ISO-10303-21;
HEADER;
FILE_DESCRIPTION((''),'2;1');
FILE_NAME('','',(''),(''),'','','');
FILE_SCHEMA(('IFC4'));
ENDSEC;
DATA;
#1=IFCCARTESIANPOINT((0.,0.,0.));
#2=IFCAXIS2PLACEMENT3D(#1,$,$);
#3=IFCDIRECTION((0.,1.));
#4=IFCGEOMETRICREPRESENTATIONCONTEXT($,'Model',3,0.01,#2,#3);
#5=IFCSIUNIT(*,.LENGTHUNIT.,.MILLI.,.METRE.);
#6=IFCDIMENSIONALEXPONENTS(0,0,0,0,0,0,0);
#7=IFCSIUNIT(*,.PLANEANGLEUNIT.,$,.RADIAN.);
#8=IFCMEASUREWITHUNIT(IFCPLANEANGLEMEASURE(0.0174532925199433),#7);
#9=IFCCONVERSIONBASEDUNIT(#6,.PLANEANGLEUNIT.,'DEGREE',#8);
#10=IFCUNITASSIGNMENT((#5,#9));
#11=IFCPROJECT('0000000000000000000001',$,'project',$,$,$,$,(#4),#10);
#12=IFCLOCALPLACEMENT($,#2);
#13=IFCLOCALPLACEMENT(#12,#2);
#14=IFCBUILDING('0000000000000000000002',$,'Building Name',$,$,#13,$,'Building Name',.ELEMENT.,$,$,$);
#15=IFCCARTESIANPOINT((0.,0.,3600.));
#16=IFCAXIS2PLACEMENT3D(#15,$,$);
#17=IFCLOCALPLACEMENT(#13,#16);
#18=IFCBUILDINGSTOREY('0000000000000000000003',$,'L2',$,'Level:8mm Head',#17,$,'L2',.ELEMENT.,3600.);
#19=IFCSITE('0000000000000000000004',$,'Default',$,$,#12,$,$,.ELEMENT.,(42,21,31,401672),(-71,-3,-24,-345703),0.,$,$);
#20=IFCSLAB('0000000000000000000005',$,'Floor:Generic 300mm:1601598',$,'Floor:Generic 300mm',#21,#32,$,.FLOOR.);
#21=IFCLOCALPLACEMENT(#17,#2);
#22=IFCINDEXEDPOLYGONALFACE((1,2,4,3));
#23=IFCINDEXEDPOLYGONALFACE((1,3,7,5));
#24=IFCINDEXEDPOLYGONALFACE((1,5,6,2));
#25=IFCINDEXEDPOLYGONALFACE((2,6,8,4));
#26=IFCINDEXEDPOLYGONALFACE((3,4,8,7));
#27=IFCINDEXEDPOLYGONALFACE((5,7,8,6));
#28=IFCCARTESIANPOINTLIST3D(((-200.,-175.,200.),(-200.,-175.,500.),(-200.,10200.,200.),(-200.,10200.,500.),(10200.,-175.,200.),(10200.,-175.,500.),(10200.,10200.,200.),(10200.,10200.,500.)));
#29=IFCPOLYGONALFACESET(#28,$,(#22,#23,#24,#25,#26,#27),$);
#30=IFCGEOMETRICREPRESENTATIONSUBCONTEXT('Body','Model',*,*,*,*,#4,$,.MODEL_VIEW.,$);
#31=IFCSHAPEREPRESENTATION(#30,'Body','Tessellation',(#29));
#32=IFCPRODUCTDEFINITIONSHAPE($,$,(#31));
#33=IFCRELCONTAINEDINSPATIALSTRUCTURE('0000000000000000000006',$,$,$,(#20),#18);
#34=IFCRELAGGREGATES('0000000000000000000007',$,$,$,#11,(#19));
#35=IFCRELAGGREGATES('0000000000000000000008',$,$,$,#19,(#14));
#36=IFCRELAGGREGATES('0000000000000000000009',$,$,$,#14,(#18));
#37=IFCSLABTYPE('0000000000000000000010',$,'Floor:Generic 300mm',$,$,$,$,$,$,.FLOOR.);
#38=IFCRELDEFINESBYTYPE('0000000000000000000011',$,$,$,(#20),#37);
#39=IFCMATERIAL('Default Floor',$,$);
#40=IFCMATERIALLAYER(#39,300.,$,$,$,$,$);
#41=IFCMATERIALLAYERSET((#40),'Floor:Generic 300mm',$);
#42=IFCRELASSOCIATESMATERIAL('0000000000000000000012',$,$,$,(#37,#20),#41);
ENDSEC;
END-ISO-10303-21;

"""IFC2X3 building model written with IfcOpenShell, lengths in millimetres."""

from ifc_helpers import new_model, entity, si_unit, converted_unit, direction, frame, frame_2d, origin, place, context, subcontext, project, spatial, rectangle, extrude, material, layer, layer_set, layer_usage, type_object, element, save


model = new_model("IFC2X3")

# Units and contexts
model_context = context("Model", 3, precision=0.01, world=origin(), true_north=direction((0.0, 1.0)))
body_context = subcontext(model_context, "Body", "Model", "MODEL_VIEW")
ifc_project = project(units=[si_unit("LENGTHUNIT", "METRE", prefix="MILLI"), converted_unit("PLANEANGLEUNIT", "DEGREE", entity("IfcPlaneAngleMeasure", 0.0174532925199433), si_unit("PLANEANGLEUNIT", "RADIAN"), dimensions=[0, 0, 0, 0, 0, 0, 0])], contexts=[model_context])

# Site, building, storey
site_placement = place(None, origin())
site = spatial("IfcSite", under=ifc_project, at=site_placement, Name="Default", CompositionType="ELEMENT", RefLatitude=(42, 21, 31, 401672), RefLongitude=(-71, -3, -24, -345703), RefElevation=0.0)
building_placement = place(site_placement, origin())
building = spatial("IfcBuilding", under=site, at=building_placement, Name="Building Name", LongName="Building Name", CompositionType="ELEMENT")
storey_placement = place(building_placement, frame((0.0, 0.0, 3600.0)))
storey = spatial("IfcBuildingStorey", under=building, at=storey_placement, Name="L2", ObjectType="Level:8mm Head", LongName="L2", CompositionType="ELEMENT", Elevation=3600.0)

# Slab
ifc_material = material(Name="Default Floor")
ifc_layer = layer(ifc_material, 300.0)
ifc_layer_set = layer_set([ifc_layer], Name="Floor:Generic 300mm")
ifc_layer_usage = layer_usage(ifc_layer_set, "AXIS3", "POSITIVE", 0.0)
slab_type = type_object("IfcSlabType", Name="Floor:Generic 300mm", PredefinedType="FLOOR", material=ifc_layer_set)
slab_placement = place(storey_placement, origin())
element("IfcSlab", 1, at=slab_placement, inside=storey, type_object=slab_type, material=ifc_layer_usage, Name="Floor:Generic 300mm:1601598", ObjectType="Floor:Generic 300mm", PredefinedType="FLOOR", context=body_context, shape_type="SweptSolid", body=[
    extrude(rectangle(XDim=10375.0, YDim=10400.0, at=frame_2d((0.0, 0.0), x_axis=(1.0, 0.0))), frame((5000.0, 5012.5, 500.0), z_axis=(0.0, 0.0, -1.0), x_axis=(0.0, 1.0, 0.0)), (0.0, 0.0, 1.0), 300.0),
])

save(model, "model.ifc")
